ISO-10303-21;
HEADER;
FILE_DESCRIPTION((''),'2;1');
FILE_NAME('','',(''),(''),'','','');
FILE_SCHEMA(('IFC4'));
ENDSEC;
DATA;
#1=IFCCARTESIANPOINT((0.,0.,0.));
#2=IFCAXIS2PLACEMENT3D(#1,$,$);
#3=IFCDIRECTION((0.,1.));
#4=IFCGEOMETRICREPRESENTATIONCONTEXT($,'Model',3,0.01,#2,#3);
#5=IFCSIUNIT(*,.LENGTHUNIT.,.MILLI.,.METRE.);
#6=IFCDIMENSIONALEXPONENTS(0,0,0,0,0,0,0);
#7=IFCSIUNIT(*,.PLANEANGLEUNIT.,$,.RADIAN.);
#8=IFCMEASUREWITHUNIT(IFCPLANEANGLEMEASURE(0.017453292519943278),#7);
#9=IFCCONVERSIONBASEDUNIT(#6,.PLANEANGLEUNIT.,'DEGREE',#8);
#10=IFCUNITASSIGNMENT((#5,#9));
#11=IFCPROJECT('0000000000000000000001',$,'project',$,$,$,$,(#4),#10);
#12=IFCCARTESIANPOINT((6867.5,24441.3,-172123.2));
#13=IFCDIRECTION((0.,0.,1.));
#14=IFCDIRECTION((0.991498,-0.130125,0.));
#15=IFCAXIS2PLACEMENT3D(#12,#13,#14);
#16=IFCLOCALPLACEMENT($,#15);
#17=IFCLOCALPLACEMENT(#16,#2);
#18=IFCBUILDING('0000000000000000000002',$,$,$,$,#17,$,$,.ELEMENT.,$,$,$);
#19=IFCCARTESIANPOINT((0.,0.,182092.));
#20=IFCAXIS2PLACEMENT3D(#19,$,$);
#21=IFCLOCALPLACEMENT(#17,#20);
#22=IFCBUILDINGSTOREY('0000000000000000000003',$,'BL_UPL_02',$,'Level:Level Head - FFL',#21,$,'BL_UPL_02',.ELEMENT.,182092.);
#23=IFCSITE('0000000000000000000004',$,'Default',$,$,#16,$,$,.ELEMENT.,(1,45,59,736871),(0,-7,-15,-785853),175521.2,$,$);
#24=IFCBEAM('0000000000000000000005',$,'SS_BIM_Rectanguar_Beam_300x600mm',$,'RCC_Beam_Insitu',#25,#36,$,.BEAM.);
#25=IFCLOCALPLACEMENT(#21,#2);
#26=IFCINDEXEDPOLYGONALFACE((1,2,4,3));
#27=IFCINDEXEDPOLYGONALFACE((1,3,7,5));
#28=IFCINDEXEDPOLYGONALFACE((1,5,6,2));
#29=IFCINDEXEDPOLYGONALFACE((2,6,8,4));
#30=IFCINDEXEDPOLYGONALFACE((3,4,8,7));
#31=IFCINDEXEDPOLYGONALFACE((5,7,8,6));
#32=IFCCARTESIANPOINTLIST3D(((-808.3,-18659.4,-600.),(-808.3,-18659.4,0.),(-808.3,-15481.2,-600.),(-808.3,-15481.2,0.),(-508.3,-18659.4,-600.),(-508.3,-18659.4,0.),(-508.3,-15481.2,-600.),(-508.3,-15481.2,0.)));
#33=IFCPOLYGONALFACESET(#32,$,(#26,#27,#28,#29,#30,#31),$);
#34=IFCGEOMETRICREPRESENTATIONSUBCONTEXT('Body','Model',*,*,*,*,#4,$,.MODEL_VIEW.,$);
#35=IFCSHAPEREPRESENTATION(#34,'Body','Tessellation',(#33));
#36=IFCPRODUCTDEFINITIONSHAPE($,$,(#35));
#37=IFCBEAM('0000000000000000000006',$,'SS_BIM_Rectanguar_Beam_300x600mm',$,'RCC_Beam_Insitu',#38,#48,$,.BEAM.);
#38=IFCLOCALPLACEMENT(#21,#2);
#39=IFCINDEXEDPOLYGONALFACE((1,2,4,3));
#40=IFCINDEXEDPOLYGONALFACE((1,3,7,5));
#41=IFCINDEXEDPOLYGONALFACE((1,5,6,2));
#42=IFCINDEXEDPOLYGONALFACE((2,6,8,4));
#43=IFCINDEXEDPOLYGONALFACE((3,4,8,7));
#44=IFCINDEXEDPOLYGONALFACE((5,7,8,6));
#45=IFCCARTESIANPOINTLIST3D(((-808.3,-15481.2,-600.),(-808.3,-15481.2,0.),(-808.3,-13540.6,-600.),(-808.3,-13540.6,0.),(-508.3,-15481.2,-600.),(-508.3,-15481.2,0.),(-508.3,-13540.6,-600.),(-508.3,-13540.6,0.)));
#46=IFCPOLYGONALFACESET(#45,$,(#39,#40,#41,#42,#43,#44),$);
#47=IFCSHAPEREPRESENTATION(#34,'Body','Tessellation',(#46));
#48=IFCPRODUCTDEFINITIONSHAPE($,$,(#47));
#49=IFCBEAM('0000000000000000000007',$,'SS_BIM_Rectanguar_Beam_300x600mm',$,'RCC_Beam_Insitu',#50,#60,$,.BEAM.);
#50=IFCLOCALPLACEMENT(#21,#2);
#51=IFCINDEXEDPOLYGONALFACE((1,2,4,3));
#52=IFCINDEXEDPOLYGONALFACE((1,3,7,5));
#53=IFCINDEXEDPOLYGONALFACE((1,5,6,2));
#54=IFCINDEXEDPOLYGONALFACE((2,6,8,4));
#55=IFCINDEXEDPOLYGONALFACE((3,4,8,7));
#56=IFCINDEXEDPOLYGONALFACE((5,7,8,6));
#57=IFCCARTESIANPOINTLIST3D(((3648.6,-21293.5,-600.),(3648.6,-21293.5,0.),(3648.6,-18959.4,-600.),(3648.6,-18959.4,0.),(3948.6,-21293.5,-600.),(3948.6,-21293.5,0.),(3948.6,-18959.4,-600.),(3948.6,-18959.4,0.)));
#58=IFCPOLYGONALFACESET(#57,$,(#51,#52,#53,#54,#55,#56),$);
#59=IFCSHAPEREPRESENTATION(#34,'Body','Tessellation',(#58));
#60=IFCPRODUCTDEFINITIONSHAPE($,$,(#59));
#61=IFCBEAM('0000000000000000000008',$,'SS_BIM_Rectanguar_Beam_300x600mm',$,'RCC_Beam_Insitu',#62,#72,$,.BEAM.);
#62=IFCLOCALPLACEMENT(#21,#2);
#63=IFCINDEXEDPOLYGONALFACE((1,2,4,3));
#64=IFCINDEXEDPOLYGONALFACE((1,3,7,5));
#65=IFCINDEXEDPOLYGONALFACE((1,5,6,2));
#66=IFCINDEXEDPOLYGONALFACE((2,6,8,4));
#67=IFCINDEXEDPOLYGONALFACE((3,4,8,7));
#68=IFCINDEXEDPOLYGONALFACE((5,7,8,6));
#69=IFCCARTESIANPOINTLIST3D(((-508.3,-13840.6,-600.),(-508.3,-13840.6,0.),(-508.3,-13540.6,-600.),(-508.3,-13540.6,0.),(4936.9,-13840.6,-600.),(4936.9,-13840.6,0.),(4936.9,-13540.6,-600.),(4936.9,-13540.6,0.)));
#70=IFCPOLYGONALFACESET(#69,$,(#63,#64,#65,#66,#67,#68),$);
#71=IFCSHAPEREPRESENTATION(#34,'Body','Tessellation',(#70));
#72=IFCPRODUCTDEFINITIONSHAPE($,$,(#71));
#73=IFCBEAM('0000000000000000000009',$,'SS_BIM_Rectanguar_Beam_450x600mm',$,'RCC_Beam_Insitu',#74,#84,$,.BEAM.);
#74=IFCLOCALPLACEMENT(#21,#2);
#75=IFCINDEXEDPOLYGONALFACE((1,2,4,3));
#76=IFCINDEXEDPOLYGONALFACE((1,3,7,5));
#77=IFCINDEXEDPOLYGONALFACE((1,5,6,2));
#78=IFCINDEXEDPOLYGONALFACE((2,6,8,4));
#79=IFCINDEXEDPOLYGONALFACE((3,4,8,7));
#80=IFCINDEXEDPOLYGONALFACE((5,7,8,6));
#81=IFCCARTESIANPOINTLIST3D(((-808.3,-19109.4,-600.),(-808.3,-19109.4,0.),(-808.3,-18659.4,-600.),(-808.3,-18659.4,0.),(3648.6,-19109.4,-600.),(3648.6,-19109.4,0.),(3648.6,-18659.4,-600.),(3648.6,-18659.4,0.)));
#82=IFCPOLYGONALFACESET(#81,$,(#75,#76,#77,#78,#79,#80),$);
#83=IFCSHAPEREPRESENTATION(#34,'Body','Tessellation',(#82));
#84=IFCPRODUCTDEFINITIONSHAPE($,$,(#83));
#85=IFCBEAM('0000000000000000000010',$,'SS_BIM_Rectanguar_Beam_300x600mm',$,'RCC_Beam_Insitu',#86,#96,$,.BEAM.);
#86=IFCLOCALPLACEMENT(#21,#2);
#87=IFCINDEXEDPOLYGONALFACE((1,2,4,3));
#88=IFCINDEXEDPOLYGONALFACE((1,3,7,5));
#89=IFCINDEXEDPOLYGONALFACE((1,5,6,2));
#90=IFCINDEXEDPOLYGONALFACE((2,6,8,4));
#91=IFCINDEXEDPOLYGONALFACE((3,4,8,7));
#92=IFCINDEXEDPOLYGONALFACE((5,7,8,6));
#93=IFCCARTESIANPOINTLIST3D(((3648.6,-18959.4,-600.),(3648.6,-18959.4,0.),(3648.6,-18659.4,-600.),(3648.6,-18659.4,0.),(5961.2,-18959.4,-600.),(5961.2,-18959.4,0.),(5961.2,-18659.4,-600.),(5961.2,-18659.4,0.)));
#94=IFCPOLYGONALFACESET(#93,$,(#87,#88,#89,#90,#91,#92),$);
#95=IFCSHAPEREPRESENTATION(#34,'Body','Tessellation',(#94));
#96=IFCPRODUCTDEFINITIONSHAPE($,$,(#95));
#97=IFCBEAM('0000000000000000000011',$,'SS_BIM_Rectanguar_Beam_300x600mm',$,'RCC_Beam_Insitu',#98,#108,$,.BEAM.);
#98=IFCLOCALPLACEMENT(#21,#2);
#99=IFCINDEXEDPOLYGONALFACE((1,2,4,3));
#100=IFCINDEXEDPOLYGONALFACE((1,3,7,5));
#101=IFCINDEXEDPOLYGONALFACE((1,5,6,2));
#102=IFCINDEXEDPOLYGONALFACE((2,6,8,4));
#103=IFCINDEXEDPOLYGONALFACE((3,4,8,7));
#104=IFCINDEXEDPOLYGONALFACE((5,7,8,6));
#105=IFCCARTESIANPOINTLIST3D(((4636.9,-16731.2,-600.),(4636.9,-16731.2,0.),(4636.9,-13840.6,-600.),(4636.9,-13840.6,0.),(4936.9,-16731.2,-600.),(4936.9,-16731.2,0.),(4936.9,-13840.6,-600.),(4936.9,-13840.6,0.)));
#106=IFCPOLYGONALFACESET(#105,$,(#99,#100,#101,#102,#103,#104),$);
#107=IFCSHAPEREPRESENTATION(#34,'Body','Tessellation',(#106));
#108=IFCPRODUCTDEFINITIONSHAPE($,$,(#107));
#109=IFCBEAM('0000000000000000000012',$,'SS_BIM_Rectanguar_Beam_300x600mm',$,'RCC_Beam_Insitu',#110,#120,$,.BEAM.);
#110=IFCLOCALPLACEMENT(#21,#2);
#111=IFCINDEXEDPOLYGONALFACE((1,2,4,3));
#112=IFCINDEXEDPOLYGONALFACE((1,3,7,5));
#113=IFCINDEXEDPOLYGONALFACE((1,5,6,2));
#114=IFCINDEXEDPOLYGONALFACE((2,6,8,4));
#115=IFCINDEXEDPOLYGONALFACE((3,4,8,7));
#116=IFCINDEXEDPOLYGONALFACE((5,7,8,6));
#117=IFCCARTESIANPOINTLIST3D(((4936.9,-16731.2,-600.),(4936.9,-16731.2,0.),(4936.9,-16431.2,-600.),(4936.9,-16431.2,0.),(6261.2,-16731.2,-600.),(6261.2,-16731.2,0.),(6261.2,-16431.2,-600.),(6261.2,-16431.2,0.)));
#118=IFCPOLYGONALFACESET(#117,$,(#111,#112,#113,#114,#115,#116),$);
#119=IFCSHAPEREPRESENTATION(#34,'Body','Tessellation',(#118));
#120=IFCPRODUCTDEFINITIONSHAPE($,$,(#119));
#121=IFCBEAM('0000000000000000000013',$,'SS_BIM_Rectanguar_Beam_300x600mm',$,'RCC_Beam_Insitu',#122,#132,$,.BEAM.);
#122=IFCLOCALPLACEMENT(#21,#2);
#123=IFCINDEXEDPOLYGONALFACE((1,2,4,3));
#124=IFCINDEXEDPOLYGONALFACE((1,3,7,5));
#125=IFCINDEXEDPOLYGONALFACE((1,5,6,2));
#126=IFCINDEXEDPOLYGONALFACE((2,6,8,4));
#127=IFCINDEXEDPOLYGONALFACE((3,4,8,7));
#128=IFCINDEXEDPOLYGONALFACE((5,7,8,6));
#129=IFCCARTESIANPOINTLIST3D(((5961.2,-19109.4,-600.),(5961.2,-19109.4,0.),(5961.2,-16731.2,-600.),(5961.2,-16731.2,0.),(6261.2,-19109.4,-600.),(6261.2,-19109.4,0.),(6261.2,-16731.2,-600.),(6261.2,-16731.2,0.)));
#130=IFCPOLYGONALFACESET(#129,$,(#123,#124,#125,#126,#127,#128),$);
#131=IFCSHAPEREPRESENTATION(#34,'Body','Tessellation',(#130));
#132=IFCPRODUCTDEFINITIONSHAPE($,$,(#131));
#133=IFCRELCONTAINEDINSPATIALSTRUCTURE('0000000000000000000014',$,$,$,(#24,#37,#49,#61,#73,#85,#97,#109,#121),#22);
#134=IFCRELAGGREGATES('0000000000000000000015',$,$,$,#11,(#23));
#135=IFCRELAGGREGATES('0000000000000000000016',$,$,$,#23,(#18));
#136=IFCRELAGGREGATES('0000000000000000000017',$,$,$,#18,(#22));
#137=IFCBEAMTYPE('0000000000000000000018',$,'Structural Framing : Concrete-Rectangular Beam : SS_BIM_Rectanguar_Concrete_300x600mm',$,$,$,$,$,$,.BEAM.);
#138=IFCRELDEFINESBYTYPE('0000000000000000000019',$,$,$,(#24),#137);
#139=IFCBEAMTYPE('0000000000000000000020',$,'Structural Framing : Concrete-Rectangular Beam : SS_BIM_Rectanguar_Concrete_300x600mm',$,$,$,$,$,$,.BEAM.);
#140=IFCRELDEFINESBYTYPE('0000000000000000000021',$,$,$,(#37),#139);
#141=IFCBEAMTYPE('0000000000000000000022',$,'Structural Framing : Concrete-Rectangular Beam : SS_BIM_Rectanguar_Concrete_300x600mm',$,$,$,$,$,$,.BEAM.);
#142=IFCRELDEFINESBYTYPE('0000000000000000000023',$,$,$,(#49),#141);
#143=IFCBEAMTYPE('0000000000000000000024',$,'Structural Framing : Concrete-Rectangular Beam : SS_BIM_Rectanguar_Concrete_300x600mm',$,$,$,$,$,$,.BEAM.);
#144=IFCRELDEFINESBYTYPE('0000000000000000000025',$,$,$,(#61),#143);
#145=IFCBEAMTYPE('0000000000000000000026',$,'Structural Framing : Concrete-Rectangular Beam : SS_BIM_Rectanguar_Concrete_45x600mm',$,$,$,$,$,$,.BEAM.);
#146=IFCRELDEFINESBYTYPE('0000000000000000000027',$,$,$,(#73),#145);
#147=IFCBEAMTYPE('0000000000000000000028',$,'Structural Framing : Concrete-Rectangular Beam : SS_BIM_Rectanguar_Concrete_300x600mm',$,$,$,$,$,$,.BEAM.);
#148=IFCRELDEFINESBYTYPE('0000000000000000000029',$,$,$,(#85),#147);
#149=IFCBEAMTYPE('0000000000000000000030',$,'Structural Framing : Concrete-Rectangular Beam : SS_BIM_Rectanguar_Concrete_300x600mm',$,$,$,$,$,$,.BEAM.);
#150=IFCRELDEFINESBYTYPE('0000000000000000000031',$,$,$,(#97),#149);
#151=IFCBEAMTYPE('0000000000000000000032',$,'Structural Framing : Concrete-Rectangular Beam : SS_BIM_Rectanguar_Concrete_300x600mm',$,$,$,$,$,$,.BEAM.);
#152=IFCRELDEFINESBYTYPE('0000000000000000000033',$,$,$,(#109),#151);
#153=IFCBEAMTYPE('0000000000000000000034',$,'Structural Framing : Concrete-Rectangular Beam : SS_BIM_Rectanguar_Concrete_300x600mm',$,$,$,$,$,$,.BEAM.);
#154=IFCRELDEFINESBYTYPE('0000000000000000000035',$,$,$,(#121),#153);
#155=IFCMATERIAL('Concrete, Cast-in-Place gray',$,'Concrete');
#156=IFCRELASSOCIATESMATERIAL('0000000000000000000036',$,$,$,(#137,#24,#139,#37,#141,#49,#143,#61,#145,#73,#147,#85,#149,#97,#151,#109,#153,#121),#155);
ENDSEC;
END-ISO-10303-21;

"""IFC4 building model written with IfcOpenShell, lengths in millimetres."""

from ifc_helpers import new_model, entity, si_unit, converted_unit, direction, frame, origin, place, context, subcontext, project, spatial, indexed_curve, outline, extrude, source, transform, mapped, material, type_object, type_shapes, element, save


model = new_model("IFC4")

# Units and contexts
model_context = context("Model", 3, precision=0.01, world=origin(), true_north=direction((0.0, 1.0)))
body_context = subcontext(model_context, "Body", "Model", "MODEL_VIEW")
ifc_project = project(units=[si_unit("LENGTHUNIT", "METRE", prefix="MILLI"), converted_unit("PLANEANGLEUNIT", "DEGREE", entity("IfcPlaneAngleMeasure", 0.017453292519943278), si_unit("PLANEANGLEUNIT", "RADIAN"), dimensions=[0, 0, 0, 0, 0, 0, 0])], contexts=[model_context])

# Site, building, storey
site_placement = place(None, frame((6867.5, 24441.3, -172123.2), z_axis=(0.0, 0.0, 1.0), x_axis=(0.991498, -0.130125, 0.0)))
site = spatial("IfcSite", under=ifc_project, at=site_placement, Name="Default", CompositionType="ELEMENT", RefLatitude=(1, 45, 59, 736871), RefLongitude=(0, -7, -15, -785853), RefElevation=175521.2)
building_placement = place(site_placement, origin())
building = spatial("IfcBuilding", under=site, at=building_placement, CompositionType="ELEMENT")
storey_placement = place(building_placement, frame((0.0, 0.0, 182092.0)))
storey = spatial("IfcBuildingStorey", under=building, at=storey_placement, Name="BL_UPL_02", ObjectType="Level:Level Head - FFL", LongName="BL_UPL_02", CompositionType="ELEMENT", Elevation=182092.0)

# Beams
ifc_material_1 = material(Name="Concrete, Cast-in-Place gray", Category="Concrete")
beam_type_1 = type_object("IfcBeamType", Name="Structural Framing : Concrete-Rectangular Beam : SS_BIM_Rectanguar_Concrete_300x600mm", PredefinedType="BEAM", material=ifc_material_1)
shared_shape_1 = source(origin(), body_context, "Body", "SweptSolid", [
    extrude(outline(indexed_curve([(-150.0, -300.0), (150.0, -300.0), (150.0, 300.0), (-150.0, 300.0), (-150.0, -300.0)], self_intersect=False)), frame((-658.3, -18659.4, 181792.0), z_axis=(0.0, 1.0, 0.0), x_axis=(-1.0, 0.0, 0.0)), (0.0, 0.0, 1.0), 3178.2),
])
type_shapes(beam_type_1, [shared_shape_1])
beam_1_placement = place(storey_placement, frame((0.0, 0.0, -182092.0)))
element("IfcBeam", 1, at=beam_1_placement, inside=storey, type_object=beam_type_1, material=ifc_material_1, Name="SS_BIM_Rectanguar_Beam_300x600mm", ObjectType="RCC_Beam_Insitu", PredefinedType="BEAM", context=body_context, shape_type="MappedRepresentation", body=[
    mapped(shared_shape_1, transform((0.0, 0.0, 0.0), scale=1.0)),
])
beam_type_2 = type_object("IfcBeamType", Name="Structural Framing : Concrete-Rectangular Beam : SS_BIM_Rectanguar_Concrete_300x600mm", PredefinedType="BEAM", material=ifc_material_1)
shared_shape_2 = source(origin(), body_context, "Body", "SweptSolid", [
    extrude(outline(indexed_curve([(-150.0, -300.0), (150.0, -300.0), (150.0, 300.0), (-150.0, 300.0), (-150.0, -300.0)], self_intersect=False)), frame((-658.3, -15481.2, 181792.0), z_axis=(0.0, 1.0, 0.0), x_axis=(-1.0, 0.0, 0.0)), (0.0, 0.0, 1.0), 1940.6),
])
type_shapes(beam_type_2, [shared_shape_2])
beam_2_placement = place(storey_placement, frame((0.0, 0.0, -182092.0)))
element("IfcBeam", 2, at=beam_2_placement, inside=storey, type_object=beam_type_2, material=ifc_material_1, Name="SS_BIM_Rectanguar_Beam_300x600mm", ObjectType="RCC_Beam_Insitu", PredefinedType="BEAM", context=body_context, shape_type="MappedRepresentation", body=[
    mapped(shared_shape_2, transform((0.0, 0.0, 0.0), scale=1.0)),
])
beam_type_3 = type_object("IfcBeamType", Name="Structural Framing : Concrete-Rectangular Beam : SS_BIM_Rectanguar_Concrete_300x600mm", PredefinedType="BEAM", material=ifc_material_1)
shared_shape_3 = source(origin(), body_context, "Body", "SweptSolid", [
    extrude(outline(indexed_curve([(-150.0, -300.0), (150.0, -300.0), (150.0, 300.0), (-150.0, 300.0), (-150.0, -300.0)], self_intersect=False)), frame((3798.6, -21293.5, 181792.0), z_axis=(0.0, 1.0, 0.0), x_axis=(-1.0, 0.0, 0.0)), (0.0, 0.0, 1.0), 2334.1),
])
type_shapes(beam_type_3, [shared_shape_3])
beam_3_placement = place(storey_placement, frame((0.0, 0.0, -182092.0)))
element("IfcBeam", 3, at=beam_3_placement, inside=storey, type_object=beam_type_3, material=ifc_material_1, Name="SS_BIM_Rectanguar_Beam_300x600mm", ObjectType="RCC_Beam_Insitu", PredefinedType="BEAM", context=body_context, shape_type="MappedRepresentation", body=[
    mapped(shared_shape_3, transform((0.0, 0.0, 0.0), scale=1.0)),
])
beam_type_4 = type_object("IfcBeamType", Name="Structural Framing : Concrete-Rectangular Beam : SS_BIM_Rectanguar_Concrete_300x600mm", PredefinedType="BEAM", material=ifc_material_1)
shared_shape_4 = source(origin(), body_context, "Body", "SweptSolid", [
    extrude(outline(indexed_curve([(-300.0, -150.0), (300.0, -150.0), (300.0, 150.0), (-300.0, 150.0), (-300.0, -150.0)], self_intersect=False)), frame((-508.3, -13690.6, 181792.0), z_axis=(1.0, 0.0, 0.0), x_axis=(0.0, 0.0, -1.0)), (0.0, 0.0, 1.0), 5445.2),
])
type_shapes(beam_type_4, [shared_shape_4])
beam_4_placement = place(storey_placement, frame((0.0, 0.0, -182092.0)))
element("IfcBeam", 4, at=beam_4_placement, inside=storey, type_object=beam_type_4, material=ifc_material_1, Name="SS_BIM_Rectanguar_Beam_300x600mm", ObjectType="RCC_Beam_Insitu", PredefinedType="BEAM", context=body_context, shape_type="MappedRepresentation", body=[
    mapped(shared_shape_4, transform((0.0, 0.0, 0.0), scale=1.0)),
])
beam_type_5 = type_object("IfcBeamType", Name="Structural Framing : Concrete-Rectangular Beam : SS_BIM_Rectanguar_Concrete_45x600mm", PredefinedType="BEAM", material=ifc_material_1)
shared_shape_5 = source(origin(), body_context, "Body", "SweptSolid", [
    extrude(outline(indexed_curve([(-300.0, -225.0), (300.0, -225.0), (300.0, 225.0), (-300.0, 225.0), (-300.0, -225.0)], self_intersect=False)), frame((-808.3, -18884.4, 181792.0), z_axis=(1.0, 0.0, 0.0), x_axis=(0.0, 0.0, -1.0)), (0.0, 0.0, 1.0), 4456.9),
])
type_shapes(beam_type_5, [shared_shape_5])
beam_5_placement = place(storey_placement, frame((0.0, 0.0, -182092.0)))
element("IfcBeam", 5, at=beam_5_placement, inside=storey, type_object=beam_type_5, material=ifc_material_1, Name="SS_BIM_Rectanguar_Beam_450x600mm", ObjectType="RCC_Beam_Insitu", PredefinedType="BEAM", context=body_context, shape_type="MappedRepresentation", body=[
    mapped(shared_shape_5, transform((0.0, 0.0, 0.0), scale=1.0)),
])
beam_type_6 = type_object("IfcBeamType", Name="Structural Framing : Concrete-Rectangular Beam : SS_BIM_Rectanguar_Concrete_300x600mm", PredefinedType="BEAM", material=ifc_material_1)
shared_shape_6 = source(origin(), body_context, "Body", "SweptSolid", [
    extrude(outline(indexed_curve([(-300.0, -150.0), (300.0, -150.0), (300.0, 150.0), (-300.0, 150.0), (-300.0, -150.0)], self_intersect=False)), frame((3648.6, -18809.4, 181792.0), z_axis=(1.0, 0.0, 0.0), x_axis=(0.0, 0.0, -1.0)), (0.0, 0.0, 1.0), 2312.6),
])
type_shapes(beam_type_6, [shared_shape_6])
beam_6_placement = place(storey_placement, frame((0.0, 0.0, -182092.0)))
element("IfcBeam", 6, at=beam_6_placement, inside=storey, type_object=beam_type_6, material=ifc_material_1, Name="SS_BIM_Rectanguar_Beam_300x600mm", ObjectType="RCC_Beam_Insitu", PredefinedType="BEAM", context=body_context, shape_type="MappedRepresentation", body=[
    mapped(shared_shape_6, transform((0.0, 0.0, 0.0), scale=1.0)),
])
beam_type_7 = type_object("IfcBeamType", Name="Structural Framing : Concrete-Rectangular Beam : SS_BIM_Rectanguar_Concrete_300x600mm", PredefinedType="BEAM", material=ifc_material_1)
shared_shape_7 = source(origin(), body_context, "Body", "SweptSolid", [
    extrude(outline(indexed_curve([(-150.0, -300.0), (150.0, -300.0), (150.0, 300.0), (-150.0, 300.0), (-150.0, -300.0)], self_intersect=False)), frame((4786.9, -13840.6, 181792.0), z_axis=(0.0, -1.0, 0.0), x_axis=(-1.0, 0.0, 0.0)), (0.0, 0.0, 1.0), 2890.6),
])
type_shapes(beam_type_7, [shared_shape_7])
beam_7_placement = place(storey_placement, frame((0.0, 0.0, -182092.0)))
element("IfcBeam", 7, at=beam_7_placement, inside=storey, type_object=beam_type_7, material=ifc_material_1, Name="SS_BIM_Rectanguar_Beam_300x600mm", ObjectType="RCC_Beam_Insitu", PredefinedType="BEAM", context=body_context, shape_type="MappedRepresentation", body=[
    mapped(shared_shape_7, transform((0.0, 0.0, 0.0), scale=1.0)),
])
beam_type_8 = type_object("IfcBeamType", Name="Structural Framing : Concrete-Rectangular Beam : SS_BIM_Rectanguar_Concrete_300x600mm", PredefinedType="BEAM", material=ifc_material_1)
shared_shape_8 = source(origin(), body_context, "Body", "SweptSolid", [
    extrude(outline(indexed_curve([(-300.0, -150.0), (300.0, -150.0), (300.0, 150.0), (-300.0, 150.0), (-300.0, -150.0)], self_intersect=False)), frame((6261.2, -16581.2, 181792.0), z_axis=(-1.0, 0.0, 0.0), x_axis=(0.0, 0.0, -1.0)), (0.0, 0.0, 1.0), 1324.3),
])
type_shapes(beam_type_8, [shared_shape_8])
beam_8_placement = place(storey_placement, frame((0.0, 0.0, -182092.0)))
element("IfcBeam", 8, at=beam_8_placement, inside=storey, type_object=beam_type_8, material=ifc_material_1, Name="SS_BIM_Rectanguar_Beam_300x600mm", ObjectType="RCC_Beam_Insitu", PredefinedType="BEAM", context=body_context, shape_type="MappedRepresentation", body=[
    mapped(shared_shape_8, transform((0.0, 0.0, 0.0), scale=1.0)),
])
beam_type_9 = type_object("IfcBeamType", Name="Structural Framing : Concrete-Rectangular Beam : SS_BIM_Rectanguar_Concrete_300x600mm", PredefinedType="BEAM", material=ifc_material_1)
shared_shape_9 = source(origin(), body_context, "Body", "SweptSolid", [
    extrude(outline(indexed_curve([(-150.0, -300.0), (150.0, -300.0), (150.0, 300.0), (-150.0, 300.0), (-150.0, -300.0)], self_intersect=False)), frame((6111.2, -16731.2, 181792.0), z_axis=(0.0, -1.0, 0.0), x_axis=(-1.0, 0.0, 0.0)), (0.0, 0.0, 1.0), 2378.2),
])
type_shapes(beam_type_9, [shared_shape_9])
beam_9_placement = place(storey_placement, frame((0.0, 0.0, -182092.0)))
element("IfcBeam", 9, at=beam_9_placement, inside=storey, type_object=beam_type_9, material=ifc_material_1, Name="SS_BIM_Rectanguar_Beam_300x600mm", ObjectType="RCC_Beam_Insitu", PredefinedType="BEAM", context=body_context, shape_type="MappedRepresentation", body=[
    mapped(shared_shape_9, transform((0.0, 0.0, 0.0), scale=1.0)),
])

save(model, "model.ifc")
